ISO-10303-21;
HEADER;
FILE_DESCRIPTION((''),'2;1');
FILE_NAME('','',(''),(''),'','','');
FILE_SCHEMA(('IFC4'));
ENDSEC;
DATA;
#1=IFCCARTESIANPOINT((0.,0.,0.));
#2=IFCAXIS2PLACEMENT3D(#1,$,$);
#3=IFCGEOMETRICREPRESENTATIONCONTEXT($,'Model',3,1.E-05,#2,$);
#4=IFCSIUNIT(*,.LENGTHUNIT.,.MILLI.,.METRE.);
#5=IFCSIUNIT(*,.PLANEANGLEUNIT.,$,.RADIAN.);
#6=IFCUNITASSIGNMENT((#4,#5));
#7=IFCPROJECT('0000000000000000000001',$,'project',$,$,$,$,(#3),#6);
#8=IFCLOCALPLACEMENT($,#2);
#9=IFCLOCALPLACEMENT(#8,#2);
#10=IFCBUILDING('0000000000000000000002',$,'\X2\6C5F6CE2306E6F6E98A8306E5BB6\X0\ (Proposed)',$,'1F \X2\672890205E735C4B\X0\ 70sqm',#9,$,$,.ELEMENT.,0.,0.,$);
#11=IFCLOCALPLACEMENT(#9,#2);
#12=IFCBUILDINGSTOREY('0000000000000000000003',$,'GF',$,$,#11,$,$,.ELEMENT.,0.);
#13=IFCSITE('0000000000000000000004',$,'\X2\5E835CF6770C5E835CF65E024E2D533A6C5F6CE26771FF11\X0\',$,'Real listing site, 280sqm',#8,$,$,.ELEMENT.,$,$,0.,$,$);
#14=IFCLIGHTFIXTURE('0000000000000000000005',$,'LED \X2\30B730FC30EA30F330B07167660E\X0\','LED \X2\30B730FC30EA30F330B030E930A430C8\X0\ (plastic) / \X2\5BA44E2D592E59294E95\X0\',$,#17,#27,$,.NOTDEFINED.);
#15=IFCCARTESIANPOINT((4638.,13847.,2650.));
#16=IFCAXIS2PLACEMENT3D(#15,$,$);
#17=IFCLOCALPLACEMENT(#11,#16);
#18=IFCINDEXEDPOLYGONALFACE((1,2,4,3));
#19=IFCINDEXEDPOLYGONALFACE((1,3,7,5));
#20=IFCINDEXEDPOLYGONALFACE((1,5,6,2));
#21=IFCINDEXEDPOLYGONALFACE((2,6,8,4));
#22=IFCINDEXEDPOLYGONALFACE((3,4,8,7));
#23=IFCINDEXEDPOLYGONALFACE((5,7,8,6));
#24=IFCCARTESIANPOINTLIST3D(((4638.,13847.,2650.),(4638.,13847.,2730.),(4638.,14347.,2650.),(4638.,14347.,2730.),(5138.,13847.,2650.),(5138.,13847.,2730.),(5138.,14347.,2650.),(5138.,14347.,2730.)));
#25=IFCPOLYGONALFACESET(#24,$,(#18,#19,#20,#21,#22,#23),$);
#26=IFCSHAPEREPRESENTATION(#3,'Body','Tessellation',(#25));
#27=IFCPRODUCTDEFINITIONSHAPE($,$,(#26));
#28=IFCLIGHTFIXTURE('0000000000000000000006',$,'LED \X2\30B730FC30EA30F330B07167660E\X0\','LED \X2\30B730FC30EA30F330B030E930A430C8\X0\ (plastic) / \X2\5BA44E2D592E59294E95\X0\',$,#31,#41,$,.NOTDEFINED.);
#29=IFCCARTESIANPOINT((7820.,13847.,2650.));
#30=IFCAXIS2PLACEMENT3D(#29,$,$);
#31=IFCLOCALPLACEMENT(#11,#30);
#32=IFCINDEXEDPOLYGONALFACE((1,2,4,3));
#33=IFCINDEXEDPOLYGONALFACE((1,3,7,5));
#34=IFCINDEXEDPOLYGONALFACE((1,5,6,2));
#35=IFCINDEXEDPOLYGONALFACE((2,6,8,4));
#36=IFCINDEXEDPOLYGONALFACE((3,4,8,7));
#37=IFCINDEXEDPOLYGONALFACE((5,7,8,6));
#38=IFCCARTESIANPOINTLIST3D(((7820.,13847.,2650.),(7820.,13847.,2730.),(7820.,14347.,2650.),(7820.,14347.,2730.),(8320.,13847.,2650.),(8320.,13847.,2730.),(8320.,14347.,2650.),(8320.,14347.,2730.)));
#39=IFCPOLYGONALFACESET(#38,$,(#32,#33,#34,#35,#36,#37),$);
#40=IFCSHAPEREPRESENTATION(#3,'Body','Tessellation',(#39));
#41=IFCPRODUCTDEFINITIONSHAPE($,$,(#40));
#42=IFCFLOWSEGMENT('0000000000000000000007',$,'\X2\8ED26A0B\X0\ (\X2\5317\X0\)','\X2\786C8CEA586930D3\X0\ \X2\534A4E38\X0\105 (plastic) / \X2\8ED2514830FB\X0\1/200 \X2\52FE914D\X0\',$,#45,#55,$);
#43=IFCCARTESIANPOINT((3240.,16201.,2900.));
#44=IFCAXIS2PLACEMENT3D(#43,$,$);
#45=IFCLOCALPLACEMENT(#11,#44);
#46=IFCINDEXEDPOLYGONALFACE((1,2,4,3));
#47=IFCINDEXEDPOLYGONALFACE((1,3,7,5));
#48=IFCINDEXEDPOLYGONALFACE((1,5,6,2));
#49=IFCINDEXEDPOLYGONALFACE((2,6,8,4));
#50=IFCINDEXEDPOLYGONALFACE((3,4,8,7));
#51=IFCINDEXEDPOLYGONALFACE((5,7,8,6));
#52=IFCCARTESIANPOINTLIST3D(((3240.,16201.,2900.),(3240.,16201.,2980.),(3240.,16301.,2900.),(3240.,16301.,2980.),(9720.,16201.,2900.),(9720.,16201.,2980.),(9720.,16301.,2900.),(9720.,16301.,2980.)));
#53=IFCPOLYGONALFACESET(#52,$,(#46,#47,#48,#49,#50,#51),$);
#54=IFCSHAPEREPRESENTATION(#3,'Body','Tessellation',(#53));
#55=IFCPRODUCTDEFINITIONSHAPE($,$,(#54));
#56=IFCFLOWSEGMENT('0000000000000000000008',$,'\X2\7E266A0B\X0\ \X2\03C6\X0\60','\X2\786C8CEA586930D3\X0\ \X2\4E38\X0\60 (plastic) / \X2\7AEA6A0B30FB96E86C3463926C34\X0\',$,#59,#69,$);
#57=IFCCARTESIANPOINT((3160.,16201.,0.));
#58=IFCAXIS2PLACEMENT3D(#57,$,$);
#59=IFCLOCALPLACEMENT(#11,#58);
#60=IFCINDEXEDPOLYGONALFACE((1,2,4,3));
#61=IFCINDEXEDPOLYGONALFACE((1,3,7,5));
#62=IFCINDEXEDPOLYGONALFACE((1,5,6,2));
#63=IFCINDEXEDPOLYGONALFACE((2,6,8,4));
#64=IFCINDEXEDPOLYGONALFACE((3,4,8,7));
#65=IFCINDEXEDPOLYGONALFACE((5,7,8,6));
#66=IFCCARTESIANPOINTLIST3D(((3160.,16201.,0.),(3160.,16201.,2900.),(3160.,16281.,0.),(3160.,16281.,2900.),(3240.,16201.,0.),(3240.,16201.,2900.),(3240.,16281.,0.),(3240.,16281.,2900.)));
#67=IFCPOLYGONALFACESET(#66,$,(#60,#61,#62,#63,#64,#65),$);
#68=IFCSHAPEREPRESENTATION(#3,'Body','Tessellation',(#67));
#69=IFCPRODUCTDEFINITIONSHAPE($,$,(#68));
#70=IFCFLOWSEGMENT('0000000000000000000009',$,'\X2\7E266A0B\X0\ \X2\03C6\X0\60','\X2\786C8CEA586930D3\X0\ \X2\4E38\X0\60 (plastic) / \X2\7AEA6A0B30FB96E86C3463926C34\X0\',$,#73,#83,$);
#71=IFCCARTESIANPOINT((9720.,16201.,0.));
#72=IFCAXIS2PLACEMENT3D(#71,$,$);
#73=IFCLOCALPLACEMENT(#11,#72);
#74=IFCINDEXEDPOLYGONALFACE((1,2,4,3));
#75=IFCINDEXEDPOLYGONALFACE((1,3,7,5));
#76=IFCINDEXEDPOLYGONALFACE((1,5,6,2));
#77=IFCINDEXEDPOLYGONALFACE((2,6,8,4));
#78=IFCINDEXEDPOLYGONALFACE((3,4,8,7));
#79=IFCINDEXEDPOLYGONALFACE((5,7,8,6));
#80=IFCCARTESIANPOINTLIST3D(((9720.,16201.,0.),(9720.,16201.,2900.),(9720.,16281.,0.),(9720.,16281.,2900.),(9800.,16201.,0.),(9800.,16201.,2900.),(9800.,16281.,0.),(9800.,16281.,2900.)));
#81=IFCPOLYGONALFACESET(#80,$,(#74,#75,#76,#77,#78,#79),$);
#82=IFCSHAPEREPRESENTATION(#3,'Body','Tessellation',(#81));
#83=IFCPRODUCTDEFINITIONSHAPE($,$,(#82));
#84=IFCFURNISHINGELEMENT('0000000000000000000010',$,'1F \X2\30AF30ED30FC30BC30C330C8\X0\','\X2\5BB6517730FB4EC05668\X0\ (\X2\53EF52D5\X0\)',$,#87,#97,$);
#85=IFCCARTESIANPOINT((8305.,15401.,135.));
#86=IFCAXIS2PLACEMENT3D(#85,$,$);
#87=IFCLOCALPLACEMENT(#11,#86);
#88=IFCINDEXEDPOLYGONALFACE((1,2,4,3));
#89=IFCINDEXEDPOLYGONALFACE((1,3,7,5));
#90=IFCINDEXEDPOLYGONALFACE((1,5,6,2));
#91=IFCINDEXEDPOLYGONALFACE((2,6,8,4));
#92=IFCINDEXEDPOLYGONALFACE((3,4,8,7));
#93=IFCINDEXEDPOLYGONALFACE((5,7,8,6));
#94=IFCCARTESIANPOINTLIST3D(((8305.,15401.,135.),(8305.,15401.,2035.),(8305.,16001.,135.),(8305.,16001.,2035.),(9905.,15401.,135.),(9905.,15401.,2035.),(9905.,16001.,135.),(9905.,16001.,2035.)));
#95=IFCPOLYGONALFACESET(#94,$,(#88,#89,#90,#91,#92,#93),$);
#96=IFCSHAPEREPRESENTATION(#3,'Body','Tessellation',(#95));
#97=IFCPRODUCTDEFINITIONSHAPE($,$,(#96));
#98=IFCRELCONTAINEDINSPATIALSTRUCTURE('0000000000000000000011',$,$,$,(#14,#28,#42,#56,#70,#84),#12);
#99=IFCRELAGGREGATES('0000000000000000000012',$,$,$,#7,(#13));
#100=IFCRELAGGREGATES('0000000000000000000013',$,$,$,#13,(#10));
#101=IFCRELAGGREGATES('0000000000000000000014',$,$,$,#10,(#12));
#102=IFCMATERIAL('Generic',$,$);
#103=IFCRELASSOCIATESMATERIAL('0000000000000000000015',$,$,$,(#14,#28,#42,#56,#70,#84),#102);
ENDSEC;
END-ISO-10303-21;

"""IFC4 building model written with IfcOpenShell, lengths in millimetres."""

from ifc_helpers import new_model, si_unit, frame, frame_2d, origin, place, context, project, spatial, rectangle, extrude, material, element, save


model = new_model("IFC4")

# Units and contexts
model_context = context("Model", 3, precision=1e-05, world=origin())
ifc_project = project(units=[si_unit("LENGTHUNIT", "METRE", prefix="MILLI"), si_unit("PLANEANGLEUNIT", "RADIAN")], contexts=[model_context])

# Site, building, storey
site_placement = place(None, origin())
site = spatial("IfcSite", under=ifc_project, at=site_placement, Name="広島県広島市中区江波東１", ObjectType="Real listing site, 280sqm", CompositionType="ELEMENT", RefElevation=0.0)
building_placement = place(site_placement, origin())
building = spatial("IfcBuilding", under=site, at=building_placement, Name="江波の潮風の家 (Proposed)", ObjectType="1F 木造平屋 70sqm", CompositionType="ELEMENT", ElevationOfRefHeight=0.0, ElevationOfTerrain=0.0)
storey_placement = place(building_placement, origin())
storey = spatial("IfcBuildingStorey", under=building, at=storey_placement, Name="GF", CompositionType="ELEMENT", Elevation=0.0)

# Shared definitions
ifc_material_1 = material(Name="Generic")

# Light fixtures
light_fixture_1_placement = place(storey_placement, frame((4638.0, 13847.0, 2650.0)))
element("IfcLightFixture", 1, at=light_fixture_1_placement, inside=storey, material=ifc_material_1, Name="LED シーリング照明", Description="LED シーリングライト (plastic) / 室中央天井", PredefinedType="NOTDEFINED", context=model_context, shape_type="SweptSolid", body=[
    extrude(rectangle(XDim=500.0, YDim=500.0, at=frame_2d((250.0, 250.0))), frame((4638.0, 13847.0, 2650.0)), (0.0, 0.0, 1.0), 80.0),
])
light_fixture_2_placement = place(storey_placement, frame((7820.0, 13847.0, 2650.0)))
element("IfcLightFixture", 2, at=light_fixture_2_placement, inside=storey, material=ifc_material_1, Name="LED シーリング照明", Description="LED シーリングライト (plastic) / 室中央天井", PredefinedType="NOTDEFINED", context=model_context, shape_type="SweptSolid", body=[
    extrude(rectangle(XDim=500.0, YDim=500.0, at=frame_2d((250.0, 250.0))), frame((7820.0, 13847.0, 2650.0)), (0.0, 0.0, 1.0), 80.0),
])

# Flow segments
flow_segment_1_placement = place(storey_placement, frame((3240.0, 16201.0, 2900.0)))
element("IfcFlowSegment", 3, at=flow_segment_1_placement, inside=storey, material=ifc_material_1, Name="軒樋 (北)", Description="硬質塩ビ 半丸105 (plastic) / 軒先・1/200 勾配", context=model_context, shape_type="SweptSolid", body=[
    extrude(rectangle(XDim=6480.0, YDim=100.0, at=frame_2d((3240.0, 50.0))), frame((3240.0, 16201.0, 2900.0)), (0.0, 0.0, 1.0), 80.0),
])
flow_segment_2_placement = place(storey_placement, frame((3160.0, 16201.0, 0.0)))
element("IfcFlowSegment", 4, at=flow_segment_2_placement, inside=storey, material=ifc_material_1, Name="縦樋 φ60", Description="硬質塩ビ 丸60 (plastic) / 竪樋・雨水排水", context=model_context, shape_type="SweptSolid", body=[
    extrude(rectangle(XDim=80.0, YDim=80.0, at=frame_2d((40.0, 40.0))), frame((3160.0, 16201.0, 0.0)), (0.0, 0.0, 1.0), 2900.0),
])
flow_segment_3_placement = place(storey_placement, frame((9720.0, 16201.0, 0.0)))
element("IfcFlowSegment", 5, at=flow_segment_3_placement, inside=storey, material=ifc_material_1, Name="縦樋 φ60", Description="硬質塩ビ 丸60 (plastic) / 竪樋・雨水排水", context=model_context, shape_type="SweptSolid", body=[
    extrude(rectangle(XDim=80.0, YDim=80.0, at=frame_2d((40.0, 40.0))), frame((9720.0, 16201.0, 0.0)), (0.0, 0.0, 1.0), 2900.0),
])

# Furnishing element
furnishing_placement = place(storey_placement, frame((8305.0, 15401.0, 135.0)))
element("IfcFurnishingElement", 6, at=furnishing_placement, inside=storey, material=ifc_material_1, Name="1F クローゼット", Description="家具・什器 (可動)", context=model_context, shape_type="SweptSolid", body=[
    extrude(rectangle(XDim=1600.0, YDim=600.0, at=frame_2d((800.0, 300.0))), frame((8305.0, 15401.0, 135.0)), (0.0, 0.0, 1.0), 1900.0),
])

save(model, "model.ifc")
